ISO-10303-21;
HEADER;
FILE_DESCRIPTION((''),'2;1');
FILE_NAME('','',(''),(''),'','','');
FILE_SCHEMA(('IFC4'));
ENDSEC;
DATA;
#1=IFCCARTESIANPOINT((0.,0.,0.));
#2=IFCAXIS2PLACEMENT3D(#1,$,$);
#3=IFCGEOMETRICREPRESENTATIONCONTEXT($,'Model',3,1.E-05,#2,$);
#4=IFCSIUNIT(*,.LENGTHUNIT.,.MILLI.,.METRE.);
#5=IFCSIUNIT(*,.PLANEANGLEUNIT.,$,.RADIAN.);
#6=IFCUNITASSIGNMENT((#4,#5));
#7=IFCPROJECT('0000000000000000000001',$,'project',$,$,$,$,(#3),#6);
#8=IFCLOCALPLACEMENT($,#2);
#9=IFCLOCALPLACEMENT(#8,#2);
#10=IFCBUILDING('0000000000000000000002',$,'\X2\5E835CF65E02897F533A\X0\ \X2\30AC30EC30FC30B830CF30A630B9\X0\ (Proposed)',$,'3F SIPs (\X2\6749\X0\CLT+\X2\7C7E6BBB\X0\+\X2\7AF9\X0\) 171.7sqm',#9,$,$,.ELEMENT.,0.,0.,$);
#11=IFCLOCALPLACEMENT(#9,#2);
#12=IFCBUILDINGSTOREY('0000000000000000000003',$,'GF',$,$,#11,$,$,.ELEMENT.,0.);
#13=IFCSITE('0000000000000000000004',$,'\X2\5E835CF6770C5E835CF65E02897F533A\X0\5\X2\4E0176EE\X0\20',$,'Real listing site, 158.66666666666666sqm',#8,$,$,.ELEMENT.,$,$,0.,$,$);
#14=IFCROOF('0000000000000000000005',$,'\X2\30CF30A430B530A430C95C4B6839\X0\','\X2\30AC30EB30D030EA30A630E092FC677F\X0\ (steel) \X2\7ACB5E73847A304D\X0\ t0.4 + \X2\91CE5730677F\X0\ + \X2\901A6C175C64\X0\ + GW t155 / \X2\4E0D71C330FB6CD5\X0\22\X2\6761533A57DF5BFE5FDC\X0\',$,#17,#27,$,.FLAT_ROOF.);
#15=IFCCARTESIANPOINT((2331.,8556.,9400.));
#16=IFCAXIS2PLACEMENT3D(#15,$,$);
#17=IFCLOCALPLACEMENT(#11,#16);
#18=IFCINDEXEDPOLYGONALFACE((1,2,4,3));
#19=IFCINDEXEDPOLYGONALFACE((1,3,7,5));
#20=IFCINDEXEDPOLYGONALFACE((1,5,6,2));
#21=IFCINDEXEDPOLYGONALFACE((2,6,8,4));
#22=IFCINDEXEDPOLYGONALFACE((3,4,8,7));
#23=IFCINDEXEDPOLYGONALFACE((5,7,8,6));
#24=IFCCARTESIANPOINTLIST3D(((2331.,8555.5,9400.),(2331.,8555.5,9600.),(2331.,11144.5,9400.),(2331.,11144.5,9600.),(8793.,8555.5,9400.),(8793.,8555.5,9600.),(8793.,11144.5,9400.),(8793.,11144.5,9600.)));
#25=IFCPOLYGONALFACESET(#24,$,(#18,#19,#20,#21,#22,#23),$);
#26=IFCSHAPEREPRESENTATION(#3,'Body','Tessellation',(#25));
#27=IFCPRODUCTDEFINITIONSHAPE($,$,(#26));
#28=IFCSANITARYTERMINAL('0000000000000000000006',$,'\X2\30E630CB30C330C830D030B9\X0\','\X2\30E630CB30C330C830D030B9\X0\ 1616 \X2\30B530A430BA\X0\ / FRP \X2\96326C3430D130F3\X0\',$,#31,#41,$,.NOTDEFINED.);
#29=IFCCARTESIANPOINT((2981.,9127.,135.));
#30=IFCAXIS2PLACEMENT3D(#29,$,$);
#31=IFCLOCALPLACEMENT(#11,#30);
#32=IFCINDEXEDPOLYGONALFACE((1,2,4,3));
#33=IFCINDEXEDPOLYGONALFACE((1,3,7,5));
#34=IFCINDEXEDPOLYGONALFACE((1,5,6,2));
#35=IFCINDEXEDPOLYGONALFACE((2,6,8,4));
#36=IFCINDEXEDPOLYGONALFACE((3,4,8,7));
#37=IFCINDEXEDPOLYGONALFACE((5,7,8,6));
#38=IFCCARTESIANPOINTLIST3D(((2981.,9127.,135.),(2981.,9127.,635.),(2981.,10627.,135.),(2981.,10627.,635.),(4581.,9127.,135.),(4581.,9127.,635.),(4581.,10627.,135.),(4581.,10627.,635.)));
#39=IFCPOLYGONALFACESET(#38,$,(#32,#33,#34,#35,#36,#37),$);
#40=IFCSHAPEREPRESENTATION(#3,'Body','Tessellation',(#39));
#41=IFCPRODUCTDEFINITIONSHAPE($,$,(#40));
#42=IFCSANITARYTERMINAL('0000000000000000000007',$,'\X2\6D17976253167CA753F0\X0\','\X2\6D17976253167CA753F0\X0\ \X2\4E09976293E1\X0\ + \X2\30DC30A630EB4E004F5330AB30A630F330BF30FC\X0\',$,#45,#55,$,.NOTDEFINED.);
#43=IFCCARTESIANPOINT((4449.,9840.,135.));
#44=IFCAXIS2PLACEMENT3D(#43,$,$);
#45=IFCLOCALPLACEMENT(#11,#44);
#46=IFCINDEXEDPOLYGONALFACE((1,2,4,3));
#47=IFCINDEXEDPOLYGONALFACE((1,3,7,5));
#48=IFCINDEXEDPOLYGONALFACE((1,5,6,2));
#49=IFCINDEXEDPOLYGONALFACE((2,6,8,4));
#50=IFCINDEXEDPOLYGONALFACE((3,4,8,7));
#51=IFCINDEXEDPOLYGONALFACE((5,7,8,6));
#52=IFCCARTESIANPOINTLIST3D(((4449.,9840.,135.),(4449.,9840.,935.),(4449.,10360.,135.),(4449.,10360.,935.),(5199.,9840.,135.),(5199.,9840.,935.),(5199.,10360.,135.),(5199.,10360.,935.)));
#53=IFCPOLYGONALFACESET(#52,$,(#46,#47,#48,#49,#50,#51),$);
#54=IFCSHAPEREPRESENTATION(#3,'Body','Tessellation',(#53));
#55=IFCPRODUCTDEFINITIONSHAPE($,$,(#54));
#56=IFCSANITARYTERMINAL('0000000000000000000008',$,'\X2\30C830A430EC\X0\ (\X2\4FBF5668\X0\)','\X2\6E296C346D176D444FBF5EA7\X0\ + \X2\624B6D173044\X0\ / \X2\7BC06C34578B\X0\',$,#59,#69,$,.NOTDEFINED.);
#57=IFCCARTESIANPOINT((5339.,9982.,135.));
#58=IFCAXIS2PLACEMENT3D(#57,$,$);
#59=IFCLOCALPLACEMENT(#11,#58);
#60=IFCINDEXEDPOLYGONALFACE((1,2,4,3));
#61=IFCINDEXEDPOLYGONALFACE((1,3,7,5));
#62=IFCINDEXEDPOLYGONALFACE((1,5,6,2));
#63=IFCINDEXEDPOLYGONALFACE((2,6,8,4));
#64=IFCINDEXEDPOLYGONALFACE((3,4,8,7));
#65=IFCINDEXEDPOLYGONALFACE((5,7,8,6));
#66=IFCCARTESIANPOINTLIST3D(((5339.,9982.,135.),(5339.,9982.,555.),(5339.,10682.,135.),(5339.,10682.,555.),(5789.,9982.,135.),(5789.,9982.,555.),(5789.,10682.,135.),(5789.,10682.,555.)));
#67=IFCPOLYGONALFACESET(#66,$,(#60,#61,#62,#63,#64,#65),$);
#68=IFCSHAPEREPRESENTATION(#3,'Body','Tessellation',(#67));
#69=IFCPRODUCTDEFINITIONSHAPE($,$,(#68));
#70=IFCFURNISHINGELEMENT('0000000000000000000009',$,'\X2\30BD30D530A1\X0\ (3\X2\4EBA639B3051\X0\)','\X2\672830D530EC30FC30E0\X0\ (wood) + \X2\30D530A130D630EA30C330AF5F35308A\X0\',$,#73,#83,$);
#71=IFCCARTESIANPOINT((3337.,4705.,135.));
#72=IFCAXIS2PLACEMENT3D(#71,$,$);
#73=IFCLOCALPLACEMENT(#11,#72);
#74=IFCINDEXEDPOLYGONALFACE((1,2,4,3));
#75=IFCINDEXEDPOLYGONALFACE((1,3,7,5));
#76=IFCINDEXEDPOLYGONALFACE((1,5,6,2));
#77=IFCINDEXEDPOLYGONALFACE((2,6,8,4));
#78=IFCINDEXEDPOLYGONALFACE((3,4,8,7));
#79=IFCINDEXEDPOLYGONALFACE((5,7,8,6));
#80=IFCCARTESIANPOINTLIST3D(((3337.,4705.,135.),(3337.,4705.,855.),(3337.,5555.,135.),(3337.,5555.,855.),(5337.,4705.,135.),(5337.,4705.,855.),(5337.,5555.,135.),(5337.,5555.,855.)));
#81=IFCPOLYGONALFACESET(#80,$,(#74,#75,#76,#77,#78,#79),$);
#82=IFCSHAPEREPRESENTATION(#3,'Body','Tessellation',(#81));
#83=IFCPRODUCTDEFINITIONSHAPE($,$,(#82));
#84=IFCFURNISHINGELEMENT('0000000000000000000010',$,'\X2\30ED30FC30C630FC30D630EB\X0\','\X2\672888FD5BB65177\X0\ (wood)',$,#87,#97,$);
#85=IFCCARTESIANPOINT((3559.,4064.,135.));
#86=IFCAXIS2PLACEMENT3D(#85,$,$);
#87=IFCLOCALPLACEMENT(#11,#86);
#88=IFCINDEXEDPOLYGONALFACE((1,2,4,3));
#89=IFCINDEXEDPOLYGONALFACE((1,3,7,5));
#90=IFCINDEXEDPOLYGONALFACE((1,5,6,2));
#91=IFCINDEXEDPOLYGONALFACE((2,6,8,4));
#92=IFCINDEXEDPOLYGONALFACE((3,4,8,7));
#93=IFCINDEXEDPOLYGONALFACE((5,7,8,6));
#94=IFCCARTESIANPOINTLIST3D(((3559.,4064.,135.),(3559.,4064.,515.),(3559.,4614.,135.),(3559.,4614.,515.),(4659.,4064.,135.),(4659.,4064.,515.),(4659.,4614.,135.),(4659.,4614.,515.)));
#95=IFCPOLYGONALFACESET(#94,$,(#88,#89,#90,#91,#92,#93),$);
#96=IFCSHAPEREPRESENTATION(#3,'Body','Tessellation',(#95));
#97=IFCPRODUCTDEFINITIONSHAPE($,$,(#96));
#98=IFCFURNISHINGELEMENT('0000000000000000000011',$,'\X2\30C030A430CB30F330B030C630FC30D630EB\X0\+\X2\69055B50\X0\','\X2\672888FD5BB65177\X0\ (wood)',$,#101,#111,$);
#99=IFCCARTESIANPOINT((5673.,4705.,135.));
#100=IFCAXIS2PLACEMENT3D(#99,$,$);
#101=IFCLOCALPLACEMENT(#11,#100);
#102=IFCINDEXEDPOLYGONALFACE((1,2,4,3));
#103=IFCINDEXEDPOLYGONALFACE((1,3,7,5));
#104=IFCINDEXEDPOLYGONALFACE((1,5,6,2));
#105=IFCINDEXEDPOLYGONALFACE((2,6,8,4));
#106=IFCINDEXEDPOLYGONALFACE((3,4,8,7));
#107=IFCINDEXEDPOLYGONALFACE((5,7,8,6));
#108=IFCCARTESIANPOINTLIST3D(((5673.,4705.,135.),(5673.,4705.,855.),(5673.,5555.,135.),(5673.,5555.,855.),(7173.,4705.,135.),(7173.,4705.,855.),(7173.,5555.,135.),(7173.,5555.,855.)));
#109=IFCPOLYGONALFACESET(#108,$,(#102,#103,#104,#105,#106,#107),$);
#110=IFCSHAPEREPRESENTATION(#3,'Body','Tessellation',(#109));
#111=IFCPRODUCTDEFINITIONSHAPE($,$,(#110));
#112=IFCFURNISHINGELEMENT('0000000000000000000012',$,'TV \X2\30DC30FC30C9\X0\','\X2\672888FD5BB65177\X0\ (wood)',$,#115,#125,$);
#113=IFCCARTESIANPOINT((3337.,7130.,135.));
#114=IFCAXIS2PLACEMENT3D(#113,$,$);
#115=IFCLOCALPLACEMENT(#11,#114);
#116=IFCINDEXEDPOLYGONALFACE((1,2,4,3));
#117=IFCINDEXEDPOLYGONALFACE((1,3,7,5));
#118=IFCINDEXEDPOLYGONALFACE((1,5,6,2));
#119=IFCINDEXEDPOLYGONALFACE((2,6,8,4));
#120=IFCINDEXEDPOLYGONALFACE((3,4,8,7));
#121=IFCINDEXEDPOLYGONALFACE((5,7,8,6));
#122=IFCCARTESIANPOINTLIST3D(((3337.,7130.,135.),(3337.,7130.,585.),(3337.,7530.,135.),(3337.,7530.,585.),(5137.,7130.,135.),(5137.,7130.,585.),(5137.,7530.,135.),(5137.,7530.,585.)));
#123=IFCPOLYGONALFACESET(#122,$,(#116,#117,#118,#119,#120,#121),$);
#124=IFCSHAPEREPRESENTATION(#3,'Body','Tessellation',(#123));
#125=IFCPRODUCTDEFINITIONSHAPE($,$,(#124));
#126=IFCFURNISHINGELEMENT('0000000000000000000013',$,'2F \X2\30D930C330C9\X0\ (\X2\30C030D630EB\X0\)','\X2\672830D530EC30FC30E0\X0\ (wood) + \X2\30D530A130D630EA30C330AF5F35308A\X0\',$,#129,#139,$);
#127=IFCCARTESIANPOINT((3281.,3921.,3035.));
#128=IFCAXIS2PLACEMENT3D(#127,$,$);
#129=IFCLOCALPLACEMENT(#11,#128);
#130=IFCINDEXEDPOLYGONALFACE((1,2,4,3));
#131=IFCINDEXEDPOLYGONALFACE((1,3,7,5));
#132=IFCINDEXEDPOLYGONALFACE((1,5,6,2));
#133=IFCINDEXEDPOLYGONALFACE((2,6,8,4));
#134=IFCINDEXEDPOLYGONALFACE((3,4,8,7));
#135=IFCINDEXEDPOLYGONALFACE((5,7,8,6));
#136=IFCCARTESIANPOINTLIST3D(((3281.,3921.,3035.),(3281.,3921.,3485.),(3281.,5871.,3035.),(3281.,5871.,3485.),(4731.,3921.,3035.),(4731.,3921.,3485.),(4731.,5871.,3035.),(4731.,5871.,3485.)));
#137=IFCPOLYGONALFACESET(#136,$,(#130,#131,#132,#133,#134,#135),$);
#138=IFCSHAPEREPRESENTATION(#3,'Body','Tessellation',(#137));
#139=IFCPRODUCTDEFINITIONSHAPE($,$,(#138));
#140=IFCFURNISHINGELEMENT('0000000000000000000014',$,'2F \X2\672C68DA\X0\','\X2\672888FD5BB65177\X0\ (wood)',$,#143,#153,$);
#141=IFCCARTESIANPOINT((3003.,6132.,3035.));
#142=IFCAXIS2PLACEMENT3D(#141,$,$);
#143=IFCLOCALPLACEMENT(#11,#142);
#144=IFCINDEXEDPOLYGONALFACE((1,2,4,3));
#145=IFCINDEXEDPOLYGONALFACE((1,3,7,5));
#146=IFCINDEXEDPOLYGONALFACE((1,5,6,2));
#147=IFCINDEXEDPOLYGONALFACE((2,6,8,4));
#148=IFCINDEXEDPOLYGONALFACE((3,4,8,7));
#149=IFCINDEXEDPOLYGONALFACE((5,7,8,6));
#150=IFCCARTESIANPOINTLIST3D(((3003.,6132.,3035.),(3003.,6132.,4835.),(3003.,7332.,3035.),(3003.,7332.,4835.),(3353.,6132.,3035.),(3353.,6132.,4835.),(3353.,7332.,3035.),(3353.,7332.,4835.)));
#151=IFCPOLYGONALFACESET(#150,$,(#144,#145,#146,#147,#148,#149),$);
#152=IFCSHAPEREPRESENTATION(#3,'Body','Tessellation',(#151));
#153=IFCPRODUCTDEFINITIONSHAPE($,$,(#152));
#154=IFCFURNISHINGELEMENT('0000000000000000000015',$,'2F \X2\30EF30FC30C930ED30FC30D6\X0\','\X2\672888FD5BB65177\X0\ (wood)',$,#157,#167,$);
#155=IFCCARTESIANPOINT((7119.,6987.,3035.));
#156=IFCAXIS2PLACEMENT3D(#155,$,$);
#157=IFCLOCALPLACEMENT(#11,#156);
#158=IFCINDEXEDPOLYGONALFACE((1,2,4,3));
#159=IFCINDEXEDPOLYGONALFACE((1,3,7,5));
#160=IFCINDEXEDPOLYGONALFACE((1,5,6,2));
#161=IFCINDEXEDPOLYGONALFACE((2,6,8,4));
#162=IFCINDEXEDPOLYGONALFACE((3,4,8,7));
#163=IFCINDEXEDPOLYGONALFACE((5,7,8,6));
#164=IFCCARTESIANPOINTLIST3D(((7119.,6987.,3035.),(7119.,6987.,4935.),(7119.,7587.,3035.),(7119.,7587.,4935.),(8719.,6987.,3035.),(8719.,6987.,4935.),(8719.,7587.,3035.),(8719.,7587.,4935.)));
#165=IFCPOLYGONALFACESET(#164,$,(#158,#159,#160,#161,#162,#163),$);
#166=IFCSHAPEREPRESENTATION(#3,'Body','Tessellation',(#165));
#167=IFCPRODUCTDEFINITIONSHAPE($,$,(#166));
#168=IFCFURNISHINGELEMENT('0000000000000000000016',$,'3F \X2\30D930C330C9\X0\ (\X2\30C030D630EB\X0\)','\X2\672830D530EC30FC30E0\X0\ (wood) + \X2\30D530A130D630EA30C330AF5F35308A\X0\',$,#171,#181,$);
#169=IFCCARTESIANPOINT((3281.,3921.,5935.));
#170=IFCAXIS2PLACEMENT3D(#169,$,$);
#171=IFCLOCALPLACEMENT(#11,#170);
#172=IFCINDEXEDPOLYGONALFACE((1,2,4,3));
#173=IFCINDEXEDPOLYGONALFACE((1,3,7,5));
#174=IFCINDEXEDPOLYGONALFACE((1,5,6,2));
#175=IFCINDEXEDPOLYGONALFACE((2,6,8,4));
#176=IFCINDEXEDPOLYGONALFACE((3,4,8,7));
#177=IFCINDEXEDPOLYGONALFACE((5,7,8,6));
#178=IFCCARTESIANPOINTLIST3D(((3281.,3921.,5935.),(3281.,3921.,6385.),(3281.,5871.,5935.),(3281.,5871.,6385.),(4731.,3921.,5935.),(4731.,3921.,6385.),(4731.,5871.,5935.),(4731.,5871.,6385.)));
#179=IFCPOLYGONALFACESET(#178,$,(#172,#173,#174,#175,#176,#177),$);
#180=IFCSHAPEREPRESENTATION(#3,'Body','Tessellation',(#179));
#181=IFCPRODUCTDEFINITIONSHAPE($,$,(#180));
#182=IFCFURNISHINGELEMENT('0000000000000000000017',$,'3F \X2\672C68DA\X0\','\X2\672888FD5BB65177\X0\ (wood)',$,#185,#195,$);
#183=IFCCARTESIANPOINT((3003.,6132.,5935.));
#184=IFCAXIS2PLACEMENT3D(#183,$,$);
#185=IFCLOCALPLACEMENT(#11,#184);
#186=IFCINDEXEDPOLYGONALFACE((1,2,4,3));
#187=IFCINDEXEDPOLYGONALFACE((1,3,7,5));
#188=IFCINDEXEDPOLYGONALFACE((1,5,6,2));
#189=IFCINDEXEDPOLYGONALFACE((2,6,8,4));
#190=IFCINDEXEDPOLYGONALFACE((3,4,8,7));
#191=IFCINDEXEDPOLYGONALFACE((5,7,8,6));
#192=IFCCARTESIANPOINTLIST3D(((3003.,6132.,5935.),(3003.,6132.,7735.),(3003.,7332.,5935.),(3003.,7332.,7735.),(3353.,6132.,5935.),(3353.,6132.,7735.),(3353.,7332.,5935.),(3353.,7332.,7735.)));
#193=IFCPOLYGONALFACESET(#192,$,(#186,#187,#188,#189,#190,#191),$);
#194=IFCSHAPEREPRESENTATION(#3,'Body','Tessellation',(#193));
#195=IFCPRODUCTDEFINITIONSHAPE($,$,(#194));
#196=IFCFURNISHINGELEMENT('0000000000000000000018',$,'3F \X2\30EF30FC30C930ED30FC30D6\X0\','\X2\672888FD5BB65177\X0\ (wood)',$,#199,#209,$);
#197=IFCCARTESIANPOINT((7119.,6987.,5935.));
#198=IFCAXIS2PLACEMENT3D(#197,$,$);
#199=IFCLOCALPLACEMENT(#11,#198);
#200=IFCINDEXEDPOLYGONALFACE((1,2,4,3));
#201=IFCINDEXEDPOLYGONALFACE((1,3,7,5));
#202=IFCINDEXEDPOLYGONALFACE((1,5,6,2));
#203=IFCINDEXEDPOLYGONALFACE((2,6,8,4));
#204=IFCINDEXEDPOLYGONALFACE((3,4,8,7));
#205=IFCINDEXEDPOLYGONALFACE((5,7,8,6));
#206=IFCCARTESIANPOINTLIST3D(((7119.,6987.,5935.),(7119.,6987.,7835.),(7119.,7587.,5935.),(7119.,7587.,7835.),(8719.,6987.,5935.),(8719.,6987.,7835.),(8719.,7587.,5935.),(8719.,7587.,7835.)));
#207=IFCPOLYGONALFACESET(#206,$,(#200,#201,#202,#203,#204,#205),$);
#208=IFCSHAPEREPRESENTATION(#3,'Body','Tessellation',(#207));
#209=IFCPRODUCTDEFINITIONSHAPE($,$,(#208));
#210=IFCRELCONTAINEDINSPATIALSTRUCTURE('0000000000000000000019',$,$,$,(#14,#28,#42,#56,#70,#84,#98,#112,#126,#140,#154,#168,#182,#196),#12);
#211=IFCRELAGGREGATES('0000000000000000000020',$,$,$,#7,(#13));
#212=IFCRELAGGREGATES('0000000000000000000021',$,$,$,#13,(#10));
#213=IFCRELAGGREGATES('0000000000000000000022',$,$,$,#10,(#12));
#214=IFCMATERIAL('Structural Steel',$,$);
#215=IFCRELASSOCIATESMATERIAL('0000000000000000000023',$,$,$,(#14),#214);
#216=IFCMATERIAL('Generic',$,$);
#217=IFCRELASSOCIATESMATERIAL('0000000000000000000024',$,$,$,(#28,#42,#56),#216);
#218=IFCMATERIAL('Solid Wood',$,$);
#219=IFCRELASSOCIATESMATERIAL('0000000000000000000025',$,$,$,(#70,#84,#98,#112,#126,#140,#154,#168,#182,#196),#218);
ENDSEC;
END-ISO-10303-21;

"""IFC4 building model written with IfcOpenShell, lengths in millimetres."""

from ifc_helpers import new_model, si_unit, frame, frame_2d, origin, place, context, project, spatial, rectangle, extrude, material, element, save


model = new_model("IFC4")

# Units and contexts
model_context = context("Model", 3, precision=1e-05, world=origin())
ifc_project = project(units=[si_unit("LENGTHUNIT", "METRE", prefix="MILLI"), si_unit("PLANEANGLEUNIT", "RADIAN")], contexts=[model_context])

# Site, building, storey
site_placement = place(None, origin())
site = spatial("IfcSite", under=ifc_project, at=site_placement, Name="広島県広島市西区5丁目20", ObjectType="Real listing site, 158.66666666666666sqm", CompositionType="ELEMENT", RefElevation=0.0)
building_placement = place(site_placement, origin())
building = spatial("IfcBuilding", under=site, at=building_placement, Name="広島市西区 ガレージハウス (Proposed)", ObjectType="3F SIPs (杉CLT+籾殻+竹) 171.7sqm", CompositionType="ELEMENT", ElevationOfRefHeight=0.0, ElevationOfTerrain=0.0)
storey_placement = place(building_placement, origin())
storey = spatial("IfcBuildingStorey", under=building, at=storey_placement, Name="GF", CompositionType="ELEMENT", Elevation=0.0)

# Shared definitions
ifc_material_1 = material(Name="Generic")

# Shared definitions
ifc_material_2 = material(Name="Solid Wood")

# Roof
ifc_material_3 = material(Name="Structural Steel")
roof_1_placement = place(storey_placement, frame((2331.0, 8556.0, 9400.0)))
element("IfcRoof", 1, at=roof_1_placement, inside=storey, material=ifc_material_3, Name="ハイサイド屋根", Description="ガルバリウム鋼板 (steel) 立平葺き t0.4 + 野地板 + 通気層 + GW t155 / 不燃・法22条区域対応", PredefinedType="FLAT_ROOF", context=model_context, shape_type="SweptSolid", body=[
    extrude(rectangle(XDim=6462.0, YDim=2589.0, at=frame_2d((3231.0, 1294.0))), frame((2331.0, 8556.0, 9400.0)), (0.0, 0.0, 1.0), 200.0),
])

# Sanitary terminals
sanitary_terminal_1_placement = place(storey_placement, frame((2981.0, 9127.0, 135.0)))
element("IfcSanitaryTerminal", 2, at=sanitary_terminal_1_placement, inside=storey, material=ifc_material_1, Name="ユニットバス", Description="ユニットバス 1616 サイズ / FRP 防水パン", PredefinedType="NOTDEFINED", context=model_context, shape_type="SweptSolid", body=[
    extrude(rectangle(XDim=1600.0, YDim=1500.0, at=frame_2d((800.0, 750.0))), frame((2981.0, 9127.0, 135.0)), (0.0, 0.0, 1.0), 500.0),
])
sanitary_terminal_2_placement = place(storey_placement, frame((4449.0, 9840.0, 135.0)))
element("IfcSanitaryTerminal", 3, at=sanitary_terminal_2_placement, inside=storey, material=ifc_material_1, Name="洗面化粧台", Description="洗面化粧台 三面鏡 + ボウル一体カウンター", PredefinedType="NOTDEFINED", context=model_context, shape_type="SweptSolid", body=[
    extrude(rectangle(XDim=750.0, YDim=520.0, at=frame_2d((375.0, 260.0))), frame((4449.0, 9840.0, 135.0)), (0.0, 0.0, 1.0), 800.0),
])
sanitary_terminal_3_placement = place(storey_placement, frame((5339.0, 9982.0, 135.0)))
element("IfcSanitaryTerminal", 4, at=sanitary_terminal_3_placement, inside=storey, material=ifc_material_1, Name="トイレ (便器)", Description="温水洗浄便座 + 手洗い / 節水型", PredefinedType="NOTDEFINED", context=model_context, shape_type="SweptSolid", body=[
    extrude(rectangle(XDim=450.0, YDim=700.0, at=frame_2d((225.0, 350.0))), frame((5339.0, 9982.0, 135.0)), (0.0, 0.0, 1.0), 420.0),
])

# Furnishing elements
furnishing_1_placement = place(storey_placement, frame((3337.0, 4705.0, 135.0)))
element("IfcFurnishingElement", 5, at=furnishing_1_placement, inside=storey, material=ifc_material_2, Name="ソファ (3人掛け)", Description="木フレーム (wood) + ファブリック張り", context=model_context, shape_type="SweptSolid", body=[
    extrude(rectangle(XDim=2000.0, YDim=850.0, at=frame_2d((1000.0, 425.0))), frame((3337.0, 4705.0, 135.0)), (0.0, 0.0, 1.0), 720.0),
])
furnishing_2_placement = place(storey_placement, frame((3559.0, 4064.0, 135.0)))
element("IfcFurnishingElement", 6, at=furnishing_2_placement, inside=storey, material=ifc_material_2, Name="ローテーブル", Description="木製家具 (wood)", context=model_context, shape_type="SweptSolid", body=[
    extrude(rectangle(XDim=1100.0, YDim=550.0, at=frame_2d((550.0, 275.0))), frame((3559.0, 4064.0, 135.0)), (0.0, 0.0, 1.0), 380.0),
])
furnishing_3_placement = place(storey_placement, frame((5673.0, 4705.0, 135.0)))
element("IfcFurnishingElement", 7, at=furnishing_3_placement, inside=storey, material=ifc_material_2, Name="ダイニングテーブル+椅子", Description="木製家具 (wood)", context=model_context, shape_type="SweptSolid", body=[
    extrude(rectangle(XDim=1500.0, YDim=850.0, at=frame_2d((750.0, 425.0))), frame((5673.0, 4705.0, 135.0)), (0.0, 0.0, 1.0), 720.0),
])
furnishing_4_placement = place(storey_placement, frame((3337.0, 7130.0, 135.0)))
element("IfcFurnishingElement", 8, at=furnishing_4_placement, inside=storey, material=ifc_material_2, Name="TV ボード", Description="木製家具 (wood)", context=model_context, shape_type="SweptSolid", body=[
    extrude(rectangle(XDim=1800.0, YDim=400.0, at=frame_2d((900.0, 200.0))), frame((3337.0, 7130.0, 135.0)), (0.0, 0.0, 1.0), 450.0),
])
furnishing_5_placement = place(storey_placement, frame((3281.0, 3921.0, 3035.0)))
element("IfcFurnishingElement", 9, at=furnishing_5_placement, inside=storey, material=ifc_material_2, Name="2F ベッド (ダブル)", Description="木フレーム (wood) + ファブリック張り", context=model_context, shape_type="SweptSolid", body=[
    extrude(rectangle(XDim=1450.0, YDim=1950.0, at=frame_2d((725.0, 975.0))), frame((3281.0, 3921.0, 3035.0)), (0.0, 0.0, 1.0), 450.0),
])
furnishing_6_placement = place(storey_placement, frame((3003.0, 6132.0, 3035.0)))
element("IfcFurnishingElement", 10, at=furnishing_6_placement, inside=storey, material=ifc_material_2, Name="2F 本棚", Description="木製家具 (wood)", context=model_context, shape_type="SweptSolid", body=[
    extrude(rectangle(XDim=350.0, YDim=1200.0, at=frame_2d((175.0, 600.0))), frame((3003.0, 6132.0, 3035.0)), (0.0, 0.0, 1.0), 1800.0),
])
furnishing_7_placement = place(storey_placement, frame((7119.0, 6987.0, 3035.0)))
element("IfcFurnishingElement", 11, at=furnishing_7_placement, inside=storey, material=ifc_material_2, Name="2F ワードローブ", Description="木製家具 (wood)", context=model_context, shape_type="SweptSolid", body=[
    extrude(rectangle(XDim=1600.0, YDim=600.0, at=frame_2d((800.0, 300.0))), frame((7119.0, 6987.0, 3035.0)), (0.0, 0.0, 1.0), 1900.0),
])
furnishing_8_placement = place(storey_placement, frame((3281.0, 3921.0, 5935.0)))
element("IfcFurnishingElement", 12, at=furnishing_8_placement, inside=storey, material=ifc_material_2, Name="3F ベッド (ダブル)", Description="木フレーム (wood) + ファブリック張り", context=model_context, shape_type="SweptSolid", body=[
    extrude(rectangle(XDim=1450.0, YDim=1950.0, at=frame_2d((725.0, 975.0))), frame((3281.0, 3921.0, 5935.0)), (0.0, 0.0, 1.0), 450.0),
])
furnishing_9_placement = place(storey_placement, frame((3003.0, 6132.0, 5935.0)))
element("IfcFurnishingElement", 13, at=furnishing_9_placement, inside=storey, material=ifc_material_2, Name="3F 本棚", Description="木製家具 (wood)", context=model_context, shape_type="SweptSolid", body=[
    extrude(rectangle(XDim=350.0, YDim=1200.0, at=frame_2d((175.0, 600.0))), frame((3003.0, 6132.0, 5935.0)), (0.0, 0.0, 1.0), 1800.0),
])
furnishing_10_placement = place(storey_placement, frame((7119.0, 6987.0, 5935.0)))
element("IfcFurnishingElement", 14, at=furnishing_10_placement, inside=storey, material=ifc_material_2, Name="3F ワードローブ", Description="木製家具 (wood)", context=model_context, shape_type="SweptSolid", body=[
    extrude(rectangle(XDim=1600.0, YDim=600.0, at=frame_2d((800.0, 300.0))), frame((7119.0, 6987.0, 5935.0)), (0.0, 0.0, 1.0), 1900.0),
])

save(model, "model.ifc")
